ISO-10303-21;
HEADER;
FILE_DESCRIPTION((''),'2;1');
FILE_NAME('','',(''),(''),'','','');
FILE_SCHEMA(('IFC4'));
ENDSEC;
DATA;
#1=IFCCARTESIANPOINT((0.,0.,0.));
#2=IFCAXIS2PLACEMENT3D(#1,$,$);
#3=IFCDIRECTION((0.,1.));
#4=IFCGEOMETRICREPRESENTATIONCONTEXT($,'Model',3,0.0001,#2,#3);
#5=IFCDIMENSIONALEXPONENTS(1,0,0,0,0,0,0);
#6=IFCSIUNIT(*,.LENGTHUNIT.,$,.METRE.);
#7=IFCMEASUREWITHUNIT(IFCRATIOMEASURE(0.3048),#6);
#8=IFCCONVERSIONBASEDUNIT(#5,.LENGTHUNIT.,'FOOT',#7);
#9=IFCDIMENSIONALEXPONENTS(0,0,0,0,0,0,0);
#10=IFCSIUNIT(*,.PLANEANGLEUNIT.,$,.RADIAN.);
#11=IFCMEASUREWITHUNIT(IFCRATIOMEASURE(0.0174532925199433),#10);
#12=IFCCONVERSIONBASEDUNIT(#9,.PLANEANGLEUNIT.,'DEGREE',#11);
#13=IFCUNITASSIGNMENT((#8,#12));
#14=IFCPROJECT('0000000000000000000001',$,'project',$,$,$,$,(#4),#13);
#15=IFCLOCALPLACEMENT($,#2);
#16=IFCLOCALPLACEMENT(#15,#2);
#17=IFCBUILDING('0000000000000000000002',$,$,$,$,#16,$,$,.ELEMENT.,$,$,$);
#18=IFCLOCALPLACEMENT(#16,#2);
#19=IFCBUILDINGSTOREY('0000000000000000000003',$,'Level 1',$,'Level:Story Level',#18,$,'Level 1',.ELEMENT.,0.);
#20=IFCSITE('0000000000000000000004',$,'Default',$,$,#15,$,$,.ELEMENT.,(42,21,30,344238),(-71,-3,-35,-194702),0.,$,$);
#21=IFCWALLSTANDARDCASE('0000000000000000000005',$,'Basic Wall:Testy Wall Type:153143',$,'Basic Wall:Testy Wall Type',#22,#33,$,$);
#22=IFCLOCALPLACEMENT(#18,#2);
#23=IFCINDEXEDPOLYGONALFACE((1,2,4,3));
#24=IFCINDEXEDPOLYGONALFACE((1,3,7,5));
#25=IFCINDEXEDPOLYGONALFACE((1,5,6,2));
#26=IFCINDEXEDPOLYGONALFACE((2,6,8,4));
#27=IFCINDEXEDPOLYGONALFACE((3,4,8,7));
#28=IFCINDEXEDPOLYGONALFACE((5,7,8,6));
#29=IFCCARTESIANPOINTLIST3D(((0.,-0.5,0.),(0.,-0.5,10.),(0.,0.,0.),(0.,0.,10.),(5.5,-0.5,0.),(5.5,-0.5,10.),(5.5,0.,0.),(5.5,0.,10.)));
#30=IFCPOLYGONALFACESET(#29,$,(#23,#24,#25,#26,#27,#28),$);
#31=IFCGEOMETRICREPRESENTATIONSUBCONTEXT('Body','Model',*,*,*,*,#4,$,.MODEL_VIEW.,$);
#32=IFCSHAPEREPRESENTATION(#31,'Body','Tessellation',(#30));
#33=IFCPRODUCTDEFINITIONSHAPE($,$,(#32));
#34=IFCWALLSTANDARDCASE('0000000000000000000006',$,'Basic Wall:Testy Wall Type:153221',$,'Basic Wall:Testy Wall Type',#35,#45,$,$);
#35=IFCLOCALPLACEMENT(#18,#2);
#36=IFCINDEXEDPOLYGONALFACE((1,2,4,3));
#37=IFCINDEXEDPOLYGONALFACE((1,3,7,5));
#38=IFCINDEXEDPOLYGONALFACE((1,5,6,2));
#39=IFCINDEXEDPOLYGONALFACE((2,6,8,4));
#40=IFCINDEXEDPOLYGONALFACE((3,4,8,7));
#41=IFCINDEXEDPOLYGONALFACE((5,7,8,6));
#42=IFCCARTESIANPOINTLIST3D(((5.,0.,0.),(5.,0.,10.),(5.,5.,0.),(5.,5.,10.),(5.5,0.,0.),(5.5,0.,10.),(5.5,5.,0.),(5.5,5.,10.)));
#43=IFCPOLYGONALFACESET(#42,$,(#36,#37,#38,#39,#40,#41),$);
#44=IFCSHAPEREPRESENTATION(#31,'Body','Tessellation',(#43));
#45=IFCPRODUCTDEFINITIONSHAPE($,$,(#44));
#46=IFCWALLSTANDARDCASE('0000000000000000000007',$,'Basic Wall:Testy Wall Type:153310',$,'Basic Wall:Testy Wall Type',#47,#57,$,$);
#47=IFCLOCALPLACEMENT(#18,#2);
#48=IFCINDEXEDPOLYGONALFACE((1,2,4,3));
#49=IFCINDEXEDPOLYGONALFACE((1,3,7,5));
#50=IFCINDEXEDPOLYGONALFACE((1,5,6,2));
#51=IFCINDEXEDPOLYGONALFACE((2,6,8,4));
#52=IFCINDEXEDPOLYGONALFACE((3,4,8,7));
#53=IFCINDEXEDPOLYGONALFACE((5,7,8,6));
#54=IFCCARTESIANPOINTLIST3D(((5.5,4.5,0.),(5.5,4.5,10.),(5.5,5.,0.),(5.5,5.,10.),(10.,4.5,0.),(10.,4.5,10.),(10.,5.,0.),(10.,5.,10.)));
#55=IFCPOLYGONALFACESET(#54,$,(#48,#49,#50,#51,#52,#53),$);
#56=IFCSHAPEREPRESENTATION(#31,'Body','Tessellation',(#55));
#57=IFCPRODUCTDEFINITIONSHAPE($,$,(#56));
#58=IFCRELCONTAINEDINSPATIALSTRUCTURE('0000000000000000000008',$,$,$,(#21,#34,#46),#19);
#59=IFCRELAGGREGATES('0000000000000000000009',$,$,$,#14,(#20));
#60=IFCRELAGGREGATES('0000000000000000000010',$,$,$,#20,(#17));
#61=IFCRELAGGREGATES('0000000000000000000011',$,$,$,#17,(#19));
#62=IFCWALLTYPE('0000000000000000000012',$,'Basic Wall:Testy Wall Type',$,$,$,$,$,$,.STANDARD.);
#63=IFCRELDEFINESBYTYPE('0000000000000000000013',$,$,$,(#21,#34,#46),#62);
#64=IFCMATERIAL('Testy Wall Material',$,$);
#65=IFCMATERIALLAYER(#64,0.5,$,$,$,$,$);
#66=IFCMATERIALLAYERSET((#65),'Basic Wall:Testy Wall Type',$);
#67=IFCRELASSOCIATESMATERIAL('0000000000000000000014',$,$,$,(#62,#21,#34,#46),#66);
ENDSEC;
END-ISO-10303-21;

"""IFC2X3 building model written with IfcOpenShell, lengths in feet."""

from ifc_helpers import new_model, entity, si_unit, converted_unit, direction, frame, frame_2d, origin, place, context, subcontext, project, spatial, rectangle, extrude, material, layer, layer_set, layer_usage, type_object, element, save


model = new_model("IFC2X3")

# Units and contexts
model_context = context("Model", 3, precision=0.0001, world=origin(), true_north=direction((0.0, 1.0)))
body_context = subcontext(model_context, "Body", "Model", "MODEL_VIEW")
ifc_project = project(units=[converted_unit("LENGTHUNIT", "FOOT", entity("IfcRatioMeasure", 0.3048), si_unit("LENGTHUNIT", "METRE"), dimensions=[1, 0, 0, 0, 0, 0, 0]), converted_unit("PLANEANGLEUNIT", "DEGREE", entity("IfcRatioMeasure", 0.0174532925199433), si_unit("PLANEANGLEUNIT", "RADIAN"), dimensions=[0, 0, 0, 0, 0, 0, 0])], contexts=[model_context])

# Site, building, storey
site_placement = place(None, origin())
site = spatial("IfcSite", under=ifc_project, at=site_placement, Name="Default", CompositionType="ELEMENT", RefLatitude=(42, 21, 30, 344238), RefLongitude=(-71, -3, -35, -194702), RefElevation=0.0)
building_placement = place(site_placement, origin())
building = spatial("IfcBuilding", under=site, at=building_placement, CompositionType="ELEMENT")
storey_placement = place(building_placement, origin())
storey = spatial("IfcBuildingStorey", under=building, at=storey_placement, Name="Level 1", ObjectType="Level:Story Level", LongName="Level 1", CompositionType="ELEMENT", Elevation=0.0)

# Walls
ifc_material = material(Name="Testy Wall Material")
ifc_layer = layer(ifc_material, 0.5)
ifc_layer_set = layer_set([ifc_layer], Name="Basic Wall:Testy Wall Type")
ifc_layer_usage_1 = layer_usage(ifc_layer_set, "AXIS2", "NEGATIVE", 0.25)
wall_type = type_object("IfcWallType", Name="Basic Wall:Testy Wall Type", PredefinedType="STANDARD", material=ifc_layer_set)
wall_1_placement = place(storey_placement, frame((0.0, -0.25, 0.0)))
element("IfcWallStandardCase", 1, at=wall_1_placement, inside=storey, type_object=wall_type, material=ifc_layer_usage_1, Name="Basic Wall:Testy Wall Type:153143", ObjectType="Basic Wall:Testy Wall Type", context=body_context, shape_type="SweptSolid", body=[
    extrude(rectangle(XDim=5.5, YDim=0.5, at=frame_2d((2.75, 0.0), x_axis=(-1.0, 0.0))), origin(), (0.0, 0.0, 1.0), 10.0),
])
ifc_layer_usage_2 = layer_usage(ifc_layer_set, "AXIS2", "NEGATIVE", 0.25)
wall_2_placement = place(storey_placement, frame((5.25, 0.0, 0.0), z_axis=(0.0, 0.0, 1.0), x_axis=(0.0, 1.0, 0.0)))
element("IfcWallStandardCase", 2, at=wall_2_placement, inside=storey, type_object=wall_type, material=ifc_layer_usage_2, Name="Basic Wall:Testy Wall Type:153221", ObjectType="Basic Wall:Testy Wall Type", context=body_context, shape_type="SweptSolid", body=[
    extrude(rectangle(XDim=5.0, YDim=0.5, at=frame_2d((2.5, 0.0), x_axis=(-1.0, 0.0))), origin(), (0.0, 0.0, 1.0), 10.0),
])
ifc_layer_usage_3 = layer_usage(ifc_layer_set, "AXIS2", "NEGATIVE", 0.25)
wall_3_placement = place(storey_placement, frame((5.5, 4.75, 0.0)))
element("IfcWallStandardCase", 3, at=wall_3_placement, inside=storey, type_object=wall_type, material=ifc_layer_usage_3, Name="Basic Wall:Testy Wall Type:153310", ObjectType="Basic Wall:Testy Wall Type", context=body_context, shape_type="SweptSolid", body=[
    extrude(rectangle(XDim=4.5, YDim=0.5, at=frame_2d((2.25, 0.0), x_axis=(-1.0, 0.0))), origin(), (0.0, 0.0, 1.0), 10.0),
])

save(model, "model.ifc")
